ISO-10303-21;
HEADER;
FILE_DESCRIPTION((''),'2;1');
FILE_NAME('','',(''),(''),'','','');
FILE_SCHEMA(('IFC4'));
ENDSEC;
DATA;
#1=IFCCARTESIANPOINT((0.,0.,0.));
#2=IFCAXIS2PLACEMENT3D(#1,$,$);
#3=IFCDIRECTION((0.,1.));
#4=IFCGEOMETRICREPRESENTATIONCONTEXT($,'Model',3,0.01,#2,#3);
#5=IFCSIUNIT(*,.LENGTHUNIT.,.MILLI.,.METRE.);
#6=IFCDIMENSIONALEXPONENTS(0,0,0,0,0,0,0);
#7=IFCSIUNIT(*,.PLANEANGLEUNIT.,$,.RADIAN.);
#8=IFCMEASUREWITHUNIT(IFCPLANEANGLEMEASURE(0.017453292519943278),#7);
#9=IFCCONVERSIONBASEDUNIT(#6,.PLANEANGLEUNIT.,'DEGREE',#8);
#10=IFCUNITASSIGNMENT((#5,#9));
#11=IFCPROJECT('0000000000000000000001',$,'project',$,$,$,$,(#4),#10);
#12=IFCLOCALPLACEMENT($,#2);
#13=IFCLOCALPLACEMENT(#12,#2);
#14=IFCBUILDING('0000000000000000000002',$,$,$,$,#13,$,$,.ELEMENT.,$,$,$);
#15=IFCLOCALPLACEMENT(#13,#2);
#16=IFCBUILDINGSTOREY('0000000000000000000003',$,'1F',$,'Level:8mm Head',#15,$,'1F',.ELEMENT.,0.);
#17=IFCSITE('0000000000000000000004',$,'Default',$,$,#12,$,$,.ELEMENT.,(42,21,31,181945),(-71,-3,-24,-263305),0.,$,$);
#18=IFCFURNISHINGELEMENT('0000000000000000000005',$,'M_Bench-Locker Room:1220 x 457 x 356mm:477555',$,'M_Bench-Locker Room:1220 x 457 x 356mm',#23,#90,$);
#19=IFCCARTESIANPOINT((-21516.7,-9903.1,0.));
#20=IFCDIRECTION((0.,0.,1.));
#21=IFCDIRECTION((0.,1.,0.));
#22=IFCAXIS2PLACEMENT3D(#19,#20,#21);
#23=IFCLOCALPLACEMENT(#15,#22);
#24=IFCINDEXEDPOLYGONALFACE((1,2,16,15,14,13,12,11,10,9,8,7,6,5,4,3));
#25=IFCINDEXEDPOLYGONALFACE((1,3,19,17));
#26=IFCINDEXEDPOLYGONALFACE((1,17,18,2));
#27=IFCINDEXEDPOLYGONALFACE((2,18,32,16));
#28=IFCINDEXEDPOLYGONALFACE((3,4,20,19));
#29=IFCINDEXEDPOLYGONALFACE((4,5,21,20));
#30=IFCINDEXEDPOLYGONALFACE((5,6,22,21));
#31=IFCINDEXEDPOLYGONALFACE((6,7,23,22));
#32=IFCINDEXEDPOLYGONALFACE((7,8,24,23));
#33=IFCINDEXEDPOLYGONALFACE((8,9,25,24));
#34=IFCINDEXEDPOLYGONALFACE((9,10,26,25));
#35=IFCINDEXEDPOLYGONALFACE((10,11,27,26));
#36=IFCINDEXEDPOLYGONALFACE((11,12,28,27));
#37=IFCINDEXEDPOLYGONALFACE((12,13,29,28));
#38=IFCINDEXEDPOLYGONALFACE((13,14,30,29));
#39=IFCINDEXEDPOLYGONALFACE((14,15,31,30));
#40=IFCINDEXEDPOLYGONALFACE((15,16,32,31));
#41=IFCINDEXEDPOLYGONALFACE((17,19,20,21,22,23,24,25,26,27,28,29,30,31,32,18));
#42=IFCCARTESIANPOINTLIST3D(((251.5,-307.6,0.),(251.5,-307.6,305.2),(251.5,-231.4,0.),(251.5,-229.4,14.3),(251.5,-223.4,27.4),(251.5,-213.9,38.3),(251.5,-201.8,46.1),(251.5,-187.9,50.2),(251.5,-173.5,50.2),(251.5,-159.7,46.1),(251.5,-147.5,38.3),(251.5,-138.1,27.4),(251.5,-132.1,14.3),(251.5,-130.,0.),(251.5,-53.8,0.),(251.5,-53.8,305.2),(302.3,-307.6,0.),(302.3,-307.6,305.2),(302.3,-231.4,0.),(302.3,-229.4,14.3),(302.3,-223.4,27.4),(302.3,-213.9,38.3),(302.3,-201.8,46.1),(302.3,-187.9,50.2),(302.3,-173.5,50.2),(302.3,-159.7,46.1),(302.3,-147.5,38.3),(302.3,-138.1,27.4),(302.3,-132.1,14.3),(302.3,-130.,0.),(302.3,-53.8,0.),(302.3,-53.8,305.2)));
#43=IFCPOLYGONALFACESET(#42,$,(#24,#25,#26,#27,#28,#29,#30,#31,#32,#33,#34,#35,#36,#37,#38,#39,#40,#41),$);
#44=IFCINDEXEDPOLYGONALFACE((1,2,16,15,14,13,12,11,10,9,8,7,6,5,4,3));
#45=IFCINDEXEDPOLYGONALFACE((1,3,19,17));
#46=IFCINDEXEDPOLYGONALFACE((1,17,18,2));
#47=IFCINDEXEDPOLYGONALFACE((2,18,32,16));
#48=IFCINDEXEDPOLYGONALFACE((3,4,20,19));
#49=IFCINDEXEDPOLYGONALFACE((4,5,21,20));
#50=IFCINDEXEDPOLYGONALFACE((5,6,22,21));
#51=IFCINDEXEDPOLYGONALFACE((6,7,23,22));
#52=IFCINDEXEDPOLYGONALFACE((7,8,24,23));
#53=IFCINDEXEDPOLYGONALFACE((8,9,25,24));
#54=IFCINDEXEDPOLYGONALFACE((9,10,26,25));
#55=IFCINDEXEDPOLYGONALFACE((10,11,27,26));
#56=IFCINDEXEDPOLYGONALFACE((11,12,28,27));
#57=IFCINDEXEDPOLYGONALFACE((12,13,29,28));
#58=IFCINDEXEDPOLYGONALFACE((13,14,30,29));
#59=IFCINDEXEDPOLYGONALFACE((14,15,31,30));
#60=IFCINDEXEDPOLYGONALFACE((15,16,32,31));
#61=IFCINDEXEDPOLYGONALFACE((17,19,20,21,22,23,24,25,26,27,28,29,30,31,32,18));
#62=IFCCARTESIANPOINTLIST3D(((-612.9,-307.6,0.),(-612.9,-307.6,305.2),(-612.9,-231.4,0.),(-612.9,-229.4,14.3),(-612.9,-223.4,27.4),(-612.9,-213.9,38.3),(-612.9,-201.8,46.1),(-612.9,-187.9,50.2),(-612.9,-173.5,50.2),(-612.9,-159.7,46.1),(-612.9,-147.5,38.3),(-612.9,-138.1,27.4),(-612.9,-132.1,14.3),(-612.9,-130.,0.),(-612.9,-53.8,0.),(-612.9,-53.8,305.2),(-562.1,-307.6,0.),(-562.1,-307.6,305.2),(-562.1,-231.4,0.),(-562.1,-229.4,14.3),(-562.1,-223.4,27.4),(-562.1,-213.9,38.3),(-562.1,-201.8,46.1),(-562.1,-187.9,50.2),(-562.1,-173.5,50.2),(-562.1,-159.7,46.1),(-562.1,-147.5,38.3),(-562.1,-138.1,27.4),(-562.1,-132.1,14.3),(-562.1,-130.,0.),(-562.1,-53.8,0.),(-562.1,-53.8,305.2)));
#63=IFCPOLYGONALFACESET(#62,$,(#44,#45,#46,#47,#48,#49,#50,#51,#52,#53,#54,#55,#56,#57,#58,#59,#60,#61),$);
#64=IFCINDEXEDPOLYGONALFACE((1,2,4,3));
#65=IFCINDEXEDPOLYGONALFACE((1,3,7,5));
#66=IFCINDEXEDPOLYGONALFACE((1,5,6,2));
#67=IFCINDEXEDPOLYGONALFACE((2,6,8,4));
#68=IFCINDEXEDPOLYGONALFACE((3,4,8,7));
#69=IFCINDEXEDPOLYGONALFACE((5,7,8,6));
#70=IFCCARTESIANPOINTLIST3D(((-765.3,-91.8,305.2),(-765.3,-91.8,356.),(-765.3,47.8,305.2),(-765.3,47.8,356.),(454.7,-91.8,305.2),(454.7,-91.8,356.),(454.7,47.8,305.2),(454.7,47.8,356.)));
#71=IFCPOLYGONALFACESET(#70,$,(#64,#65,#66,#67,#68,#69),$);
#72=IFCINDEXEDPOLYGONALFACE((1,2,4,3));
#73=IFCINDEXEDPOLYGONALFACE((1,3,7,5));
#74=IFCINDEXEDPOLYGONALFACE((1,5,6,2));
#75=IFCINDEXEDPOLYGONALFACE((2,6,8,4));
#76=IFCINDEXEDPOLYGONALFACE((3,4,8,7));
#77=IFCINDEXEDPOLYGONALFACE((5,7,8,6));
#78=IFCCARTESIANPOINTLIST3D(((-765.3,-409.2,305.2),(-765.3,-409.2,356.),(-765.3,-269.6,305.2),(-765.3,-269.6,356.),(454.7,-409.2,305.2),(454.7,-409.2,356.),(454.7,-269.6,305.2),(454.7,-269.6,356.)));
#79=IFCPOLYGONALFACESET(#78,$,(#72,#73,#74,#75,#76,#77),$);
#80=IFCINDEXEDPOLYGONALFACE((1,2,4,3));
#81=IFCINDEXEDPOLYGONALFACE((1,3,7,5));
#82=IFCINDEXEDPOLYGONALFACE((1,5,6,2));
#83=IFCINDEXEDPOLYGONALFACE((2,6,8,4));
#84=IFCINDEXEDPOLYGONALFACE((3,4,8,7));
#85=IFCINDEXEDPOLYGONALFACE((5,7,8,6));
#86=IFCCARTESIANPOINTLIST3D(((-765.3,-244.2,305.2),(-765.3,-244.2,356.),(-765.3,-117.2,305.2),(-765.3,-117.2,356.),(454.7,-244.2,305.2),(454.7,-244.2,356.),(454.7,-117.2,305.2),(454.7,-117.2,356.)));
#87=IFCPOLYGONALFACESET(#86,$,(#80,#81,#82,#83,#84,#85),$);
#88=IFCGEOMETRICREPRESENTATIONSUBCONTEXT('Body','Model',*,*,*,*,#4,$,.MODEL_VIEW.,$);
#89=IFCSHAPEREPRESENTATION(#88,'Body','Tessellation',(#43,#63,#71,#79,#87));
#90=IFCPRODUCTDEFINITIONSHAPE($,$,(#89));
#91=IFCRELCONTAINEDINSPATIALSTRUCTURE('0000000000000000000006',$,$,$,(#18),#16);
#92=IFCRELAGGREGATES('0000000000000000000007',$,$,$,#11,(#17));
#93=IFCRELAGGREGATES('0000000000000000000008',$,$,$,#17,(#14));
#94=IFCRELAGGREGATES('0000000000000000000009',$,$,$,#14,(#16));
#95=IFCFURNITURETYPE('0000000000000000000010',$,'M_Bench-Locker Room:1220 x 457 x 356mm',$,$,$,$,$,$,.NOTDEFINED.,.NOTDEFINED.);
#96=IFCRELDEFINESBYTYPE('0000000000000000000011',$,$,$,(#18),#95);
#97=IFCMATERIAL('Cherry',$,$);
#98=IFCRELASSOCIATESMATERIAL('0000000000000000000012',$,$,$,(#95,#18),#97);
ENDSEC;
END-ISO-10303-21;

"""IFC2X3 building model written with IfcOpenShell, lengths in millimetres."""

from ifc_helpers import new_model, entity, si_unit, converted_unit, direction, frame, frame_2d, origin, origin_2d_with_axis, place, context, subcontext, project, spatial, polyline, circle_curve, parameter, trimmed, segment, composite_curve, rectangle, outline, extrude, source, transform, mapped, material, type_object, type_shapes, element, save


model = new_model("IFC2X3")

# Units and contexts
model_context = context("Model", 3, precision=0.01, world=origin(), true_north=direction((0.0, 1.0)))
body_context = subcontext(model_context, "Body", "Model", "MODEL_VIEW")
ifc_project = project(units=[si_unit("LENGTHUNIT", "METRE", prefix="MILLI"), converted_unit("PLANEANGLEUNIT", "DEGREE", entity("IfcPlaneAngleMeasure", 0.017453292519943278), si_unit("PLANEANGLEUNIT", "RADIAN"), dimensions=[0, 0, 0, 0, 0, 0, 0])], contexts=[model_context])

# Site, building, storey
site_placement = place(None, origin())
site = spatial("IfcSite", under=ifc_project, at=site_placement, Name="Default", CompositionType="ELEMENT", RefLatitude=(42, 21, 31, 181945), RefLongitude=(-71, -3, -24, -263305), RefElevation=0.0)
building_placement = place(site_placement, origin())
building = spatial("IfcBuilding", under=site, at=building_placement, CompositionType="ELEMENT")
storey_placement = place(building_placement, origin())
storey = spatial("IfcBuildingStorey", under=building, at=storey_placement, Name="1F", ObjectType="Level:8mm Head", LongName="1F", CompositionType="ELEMENT", Elevation=0.0)

# Furnishing element
ifc_material_1 = material(Name="Cherry")
furniture_type = type_object("IfcFurnitureType", Name="M_Bench-Locker Room:1220 x 457 x 356mm", AssemblyPlace="NOTDEFINED", material=ifc_material_1)
shared_shape = source(origin(), body_context, "Body", "SweptSolid", [
    extrude(outline(composite_curve([segment(polyline([(-126.9, 101.7), (-126.9, -203.5)]), True, "CONTINUOUS"), segment(polyline([(-126.9, -203.5), (126.9, -203.5)]), True, "CONTINUOUS"), segment(polyline([(126.9, -203.5), (126.9, 101.7)]), True, "CONTINUOUS"), segment(polyline([(126.9, 101.7), (50.7, 101.7)]), True, "CONTINUOUS"), segment(trimmed(circle_curve(frame_2d((0.0, 101.7), x_axis=(0.0, 1.0)), 50.7), [parameter(90.0)], [parameter(270.0)], True, "PARAMETER"), False, "CONTINUOUS"), segment(polyline([(-50.7, 101.7), (-126.9, 101.7)]), True, "CONTINUOUS")], self_intersect=False)), frame((251.5, -180.7, 101.7), z_axis=(-1.0, 0.0, 0.0), x_axis=(0.0, 1.0, 0.0)), (0.0, 0.0, -1.0), 50.8),
    extrude(outline(composite_curve([segment(polyline([(-101.7, -126.9), (203.5, -126.9)]), True, "CONTINUOUS"), segment(polyline([(203.5, -126.9), (203.5, 126.9)]), True, "CONTINUOUS"), segment(polyline([(203.5, 126.9), (-101.7, 126.9)]), True, "CONTINUOUS"), segment(polyline([(-101.7, 126.9), (-101.7, 50.7)]), True, "CONTINUOUS"), segment(trimmed(circle_curve(frame_2d((-101.7, 0.0), x_axis=(-1.0, 0.0)), 50.7), [parameter(90.0)], [parameter(270.0)], True, "PARAMETER"), False, "CONTINUOUS"), segment(polyline([(-101.7, -50.7), (-101.7, -126.9)]), True, "CONTINUOUS")], self_intersect=False)), frame((-612.9, -180.7, 101.7), z_axis=(1.0, 0.0, 0.0), x_axis=(0.0, 0.0, 1.0)), (0.0, 0.0, 1.0), 50.8),
    extrude(rectangle(XDim=1220.0, YDim=139.6, at=origin_2d_with_axis()), frame((-155.3, -22.0, 305.2), z_axis=(0.0, 0.0, 1.0), x_axis=(-1.0, 0.0, 0.0)), (0.0, 0.0, 1.0), 50.8),
    extrude(rectangle(XDim=139.6, YDim=1220.0, at=frame_2d((0.0, 0.0), x_axis=(1.0, 0.0))), frame((-155.3, -339.4, 305.2), z_axis=(0.0, 0.0, 1.0), x_axis=(0.0, 1.0, 0.0)), (0.0, 0.0, 1.0), 50.8),
    extrude(rectangle(XDim=1220.0, YDim=126.9, at=frame_2d((0.0, 0.0), x_axis=(1.0, 0.0))), frame((-155.3, -180.7, 305.2), z_axis=(0.0, 0.0, 1.0), x_axis=(-1.0, 0.0, 0.0)), (0.0, 0.0, 1.0), 50.8),
])
type_shapes(furniture_type, [shared_shape])
furnishing_placement = place(storey_placement, frame((-21516.7, -9903.1, 0.0), z_axis=(0.0, 0.0, 1.0), x_axis=(0.0, 1.0, 0.0)))
element("IfcFurnishingElement", 1, at=furnishing_placement, inside=storey, type_object=furniture_type, material=ifc_material_1, Name="M_Bench-Locker Room:1220 x 457 x 356mm:477555", ObjectType="M_Bench-Locker Room:1220 x 457 x 356mm", context=body_context, shape_type="MappedRepresentation", body=[
    mapped(shared_shape, transform((0.0, 0.0, 0.0), scale=1.0)),
])

save(model, "model.ifc")
